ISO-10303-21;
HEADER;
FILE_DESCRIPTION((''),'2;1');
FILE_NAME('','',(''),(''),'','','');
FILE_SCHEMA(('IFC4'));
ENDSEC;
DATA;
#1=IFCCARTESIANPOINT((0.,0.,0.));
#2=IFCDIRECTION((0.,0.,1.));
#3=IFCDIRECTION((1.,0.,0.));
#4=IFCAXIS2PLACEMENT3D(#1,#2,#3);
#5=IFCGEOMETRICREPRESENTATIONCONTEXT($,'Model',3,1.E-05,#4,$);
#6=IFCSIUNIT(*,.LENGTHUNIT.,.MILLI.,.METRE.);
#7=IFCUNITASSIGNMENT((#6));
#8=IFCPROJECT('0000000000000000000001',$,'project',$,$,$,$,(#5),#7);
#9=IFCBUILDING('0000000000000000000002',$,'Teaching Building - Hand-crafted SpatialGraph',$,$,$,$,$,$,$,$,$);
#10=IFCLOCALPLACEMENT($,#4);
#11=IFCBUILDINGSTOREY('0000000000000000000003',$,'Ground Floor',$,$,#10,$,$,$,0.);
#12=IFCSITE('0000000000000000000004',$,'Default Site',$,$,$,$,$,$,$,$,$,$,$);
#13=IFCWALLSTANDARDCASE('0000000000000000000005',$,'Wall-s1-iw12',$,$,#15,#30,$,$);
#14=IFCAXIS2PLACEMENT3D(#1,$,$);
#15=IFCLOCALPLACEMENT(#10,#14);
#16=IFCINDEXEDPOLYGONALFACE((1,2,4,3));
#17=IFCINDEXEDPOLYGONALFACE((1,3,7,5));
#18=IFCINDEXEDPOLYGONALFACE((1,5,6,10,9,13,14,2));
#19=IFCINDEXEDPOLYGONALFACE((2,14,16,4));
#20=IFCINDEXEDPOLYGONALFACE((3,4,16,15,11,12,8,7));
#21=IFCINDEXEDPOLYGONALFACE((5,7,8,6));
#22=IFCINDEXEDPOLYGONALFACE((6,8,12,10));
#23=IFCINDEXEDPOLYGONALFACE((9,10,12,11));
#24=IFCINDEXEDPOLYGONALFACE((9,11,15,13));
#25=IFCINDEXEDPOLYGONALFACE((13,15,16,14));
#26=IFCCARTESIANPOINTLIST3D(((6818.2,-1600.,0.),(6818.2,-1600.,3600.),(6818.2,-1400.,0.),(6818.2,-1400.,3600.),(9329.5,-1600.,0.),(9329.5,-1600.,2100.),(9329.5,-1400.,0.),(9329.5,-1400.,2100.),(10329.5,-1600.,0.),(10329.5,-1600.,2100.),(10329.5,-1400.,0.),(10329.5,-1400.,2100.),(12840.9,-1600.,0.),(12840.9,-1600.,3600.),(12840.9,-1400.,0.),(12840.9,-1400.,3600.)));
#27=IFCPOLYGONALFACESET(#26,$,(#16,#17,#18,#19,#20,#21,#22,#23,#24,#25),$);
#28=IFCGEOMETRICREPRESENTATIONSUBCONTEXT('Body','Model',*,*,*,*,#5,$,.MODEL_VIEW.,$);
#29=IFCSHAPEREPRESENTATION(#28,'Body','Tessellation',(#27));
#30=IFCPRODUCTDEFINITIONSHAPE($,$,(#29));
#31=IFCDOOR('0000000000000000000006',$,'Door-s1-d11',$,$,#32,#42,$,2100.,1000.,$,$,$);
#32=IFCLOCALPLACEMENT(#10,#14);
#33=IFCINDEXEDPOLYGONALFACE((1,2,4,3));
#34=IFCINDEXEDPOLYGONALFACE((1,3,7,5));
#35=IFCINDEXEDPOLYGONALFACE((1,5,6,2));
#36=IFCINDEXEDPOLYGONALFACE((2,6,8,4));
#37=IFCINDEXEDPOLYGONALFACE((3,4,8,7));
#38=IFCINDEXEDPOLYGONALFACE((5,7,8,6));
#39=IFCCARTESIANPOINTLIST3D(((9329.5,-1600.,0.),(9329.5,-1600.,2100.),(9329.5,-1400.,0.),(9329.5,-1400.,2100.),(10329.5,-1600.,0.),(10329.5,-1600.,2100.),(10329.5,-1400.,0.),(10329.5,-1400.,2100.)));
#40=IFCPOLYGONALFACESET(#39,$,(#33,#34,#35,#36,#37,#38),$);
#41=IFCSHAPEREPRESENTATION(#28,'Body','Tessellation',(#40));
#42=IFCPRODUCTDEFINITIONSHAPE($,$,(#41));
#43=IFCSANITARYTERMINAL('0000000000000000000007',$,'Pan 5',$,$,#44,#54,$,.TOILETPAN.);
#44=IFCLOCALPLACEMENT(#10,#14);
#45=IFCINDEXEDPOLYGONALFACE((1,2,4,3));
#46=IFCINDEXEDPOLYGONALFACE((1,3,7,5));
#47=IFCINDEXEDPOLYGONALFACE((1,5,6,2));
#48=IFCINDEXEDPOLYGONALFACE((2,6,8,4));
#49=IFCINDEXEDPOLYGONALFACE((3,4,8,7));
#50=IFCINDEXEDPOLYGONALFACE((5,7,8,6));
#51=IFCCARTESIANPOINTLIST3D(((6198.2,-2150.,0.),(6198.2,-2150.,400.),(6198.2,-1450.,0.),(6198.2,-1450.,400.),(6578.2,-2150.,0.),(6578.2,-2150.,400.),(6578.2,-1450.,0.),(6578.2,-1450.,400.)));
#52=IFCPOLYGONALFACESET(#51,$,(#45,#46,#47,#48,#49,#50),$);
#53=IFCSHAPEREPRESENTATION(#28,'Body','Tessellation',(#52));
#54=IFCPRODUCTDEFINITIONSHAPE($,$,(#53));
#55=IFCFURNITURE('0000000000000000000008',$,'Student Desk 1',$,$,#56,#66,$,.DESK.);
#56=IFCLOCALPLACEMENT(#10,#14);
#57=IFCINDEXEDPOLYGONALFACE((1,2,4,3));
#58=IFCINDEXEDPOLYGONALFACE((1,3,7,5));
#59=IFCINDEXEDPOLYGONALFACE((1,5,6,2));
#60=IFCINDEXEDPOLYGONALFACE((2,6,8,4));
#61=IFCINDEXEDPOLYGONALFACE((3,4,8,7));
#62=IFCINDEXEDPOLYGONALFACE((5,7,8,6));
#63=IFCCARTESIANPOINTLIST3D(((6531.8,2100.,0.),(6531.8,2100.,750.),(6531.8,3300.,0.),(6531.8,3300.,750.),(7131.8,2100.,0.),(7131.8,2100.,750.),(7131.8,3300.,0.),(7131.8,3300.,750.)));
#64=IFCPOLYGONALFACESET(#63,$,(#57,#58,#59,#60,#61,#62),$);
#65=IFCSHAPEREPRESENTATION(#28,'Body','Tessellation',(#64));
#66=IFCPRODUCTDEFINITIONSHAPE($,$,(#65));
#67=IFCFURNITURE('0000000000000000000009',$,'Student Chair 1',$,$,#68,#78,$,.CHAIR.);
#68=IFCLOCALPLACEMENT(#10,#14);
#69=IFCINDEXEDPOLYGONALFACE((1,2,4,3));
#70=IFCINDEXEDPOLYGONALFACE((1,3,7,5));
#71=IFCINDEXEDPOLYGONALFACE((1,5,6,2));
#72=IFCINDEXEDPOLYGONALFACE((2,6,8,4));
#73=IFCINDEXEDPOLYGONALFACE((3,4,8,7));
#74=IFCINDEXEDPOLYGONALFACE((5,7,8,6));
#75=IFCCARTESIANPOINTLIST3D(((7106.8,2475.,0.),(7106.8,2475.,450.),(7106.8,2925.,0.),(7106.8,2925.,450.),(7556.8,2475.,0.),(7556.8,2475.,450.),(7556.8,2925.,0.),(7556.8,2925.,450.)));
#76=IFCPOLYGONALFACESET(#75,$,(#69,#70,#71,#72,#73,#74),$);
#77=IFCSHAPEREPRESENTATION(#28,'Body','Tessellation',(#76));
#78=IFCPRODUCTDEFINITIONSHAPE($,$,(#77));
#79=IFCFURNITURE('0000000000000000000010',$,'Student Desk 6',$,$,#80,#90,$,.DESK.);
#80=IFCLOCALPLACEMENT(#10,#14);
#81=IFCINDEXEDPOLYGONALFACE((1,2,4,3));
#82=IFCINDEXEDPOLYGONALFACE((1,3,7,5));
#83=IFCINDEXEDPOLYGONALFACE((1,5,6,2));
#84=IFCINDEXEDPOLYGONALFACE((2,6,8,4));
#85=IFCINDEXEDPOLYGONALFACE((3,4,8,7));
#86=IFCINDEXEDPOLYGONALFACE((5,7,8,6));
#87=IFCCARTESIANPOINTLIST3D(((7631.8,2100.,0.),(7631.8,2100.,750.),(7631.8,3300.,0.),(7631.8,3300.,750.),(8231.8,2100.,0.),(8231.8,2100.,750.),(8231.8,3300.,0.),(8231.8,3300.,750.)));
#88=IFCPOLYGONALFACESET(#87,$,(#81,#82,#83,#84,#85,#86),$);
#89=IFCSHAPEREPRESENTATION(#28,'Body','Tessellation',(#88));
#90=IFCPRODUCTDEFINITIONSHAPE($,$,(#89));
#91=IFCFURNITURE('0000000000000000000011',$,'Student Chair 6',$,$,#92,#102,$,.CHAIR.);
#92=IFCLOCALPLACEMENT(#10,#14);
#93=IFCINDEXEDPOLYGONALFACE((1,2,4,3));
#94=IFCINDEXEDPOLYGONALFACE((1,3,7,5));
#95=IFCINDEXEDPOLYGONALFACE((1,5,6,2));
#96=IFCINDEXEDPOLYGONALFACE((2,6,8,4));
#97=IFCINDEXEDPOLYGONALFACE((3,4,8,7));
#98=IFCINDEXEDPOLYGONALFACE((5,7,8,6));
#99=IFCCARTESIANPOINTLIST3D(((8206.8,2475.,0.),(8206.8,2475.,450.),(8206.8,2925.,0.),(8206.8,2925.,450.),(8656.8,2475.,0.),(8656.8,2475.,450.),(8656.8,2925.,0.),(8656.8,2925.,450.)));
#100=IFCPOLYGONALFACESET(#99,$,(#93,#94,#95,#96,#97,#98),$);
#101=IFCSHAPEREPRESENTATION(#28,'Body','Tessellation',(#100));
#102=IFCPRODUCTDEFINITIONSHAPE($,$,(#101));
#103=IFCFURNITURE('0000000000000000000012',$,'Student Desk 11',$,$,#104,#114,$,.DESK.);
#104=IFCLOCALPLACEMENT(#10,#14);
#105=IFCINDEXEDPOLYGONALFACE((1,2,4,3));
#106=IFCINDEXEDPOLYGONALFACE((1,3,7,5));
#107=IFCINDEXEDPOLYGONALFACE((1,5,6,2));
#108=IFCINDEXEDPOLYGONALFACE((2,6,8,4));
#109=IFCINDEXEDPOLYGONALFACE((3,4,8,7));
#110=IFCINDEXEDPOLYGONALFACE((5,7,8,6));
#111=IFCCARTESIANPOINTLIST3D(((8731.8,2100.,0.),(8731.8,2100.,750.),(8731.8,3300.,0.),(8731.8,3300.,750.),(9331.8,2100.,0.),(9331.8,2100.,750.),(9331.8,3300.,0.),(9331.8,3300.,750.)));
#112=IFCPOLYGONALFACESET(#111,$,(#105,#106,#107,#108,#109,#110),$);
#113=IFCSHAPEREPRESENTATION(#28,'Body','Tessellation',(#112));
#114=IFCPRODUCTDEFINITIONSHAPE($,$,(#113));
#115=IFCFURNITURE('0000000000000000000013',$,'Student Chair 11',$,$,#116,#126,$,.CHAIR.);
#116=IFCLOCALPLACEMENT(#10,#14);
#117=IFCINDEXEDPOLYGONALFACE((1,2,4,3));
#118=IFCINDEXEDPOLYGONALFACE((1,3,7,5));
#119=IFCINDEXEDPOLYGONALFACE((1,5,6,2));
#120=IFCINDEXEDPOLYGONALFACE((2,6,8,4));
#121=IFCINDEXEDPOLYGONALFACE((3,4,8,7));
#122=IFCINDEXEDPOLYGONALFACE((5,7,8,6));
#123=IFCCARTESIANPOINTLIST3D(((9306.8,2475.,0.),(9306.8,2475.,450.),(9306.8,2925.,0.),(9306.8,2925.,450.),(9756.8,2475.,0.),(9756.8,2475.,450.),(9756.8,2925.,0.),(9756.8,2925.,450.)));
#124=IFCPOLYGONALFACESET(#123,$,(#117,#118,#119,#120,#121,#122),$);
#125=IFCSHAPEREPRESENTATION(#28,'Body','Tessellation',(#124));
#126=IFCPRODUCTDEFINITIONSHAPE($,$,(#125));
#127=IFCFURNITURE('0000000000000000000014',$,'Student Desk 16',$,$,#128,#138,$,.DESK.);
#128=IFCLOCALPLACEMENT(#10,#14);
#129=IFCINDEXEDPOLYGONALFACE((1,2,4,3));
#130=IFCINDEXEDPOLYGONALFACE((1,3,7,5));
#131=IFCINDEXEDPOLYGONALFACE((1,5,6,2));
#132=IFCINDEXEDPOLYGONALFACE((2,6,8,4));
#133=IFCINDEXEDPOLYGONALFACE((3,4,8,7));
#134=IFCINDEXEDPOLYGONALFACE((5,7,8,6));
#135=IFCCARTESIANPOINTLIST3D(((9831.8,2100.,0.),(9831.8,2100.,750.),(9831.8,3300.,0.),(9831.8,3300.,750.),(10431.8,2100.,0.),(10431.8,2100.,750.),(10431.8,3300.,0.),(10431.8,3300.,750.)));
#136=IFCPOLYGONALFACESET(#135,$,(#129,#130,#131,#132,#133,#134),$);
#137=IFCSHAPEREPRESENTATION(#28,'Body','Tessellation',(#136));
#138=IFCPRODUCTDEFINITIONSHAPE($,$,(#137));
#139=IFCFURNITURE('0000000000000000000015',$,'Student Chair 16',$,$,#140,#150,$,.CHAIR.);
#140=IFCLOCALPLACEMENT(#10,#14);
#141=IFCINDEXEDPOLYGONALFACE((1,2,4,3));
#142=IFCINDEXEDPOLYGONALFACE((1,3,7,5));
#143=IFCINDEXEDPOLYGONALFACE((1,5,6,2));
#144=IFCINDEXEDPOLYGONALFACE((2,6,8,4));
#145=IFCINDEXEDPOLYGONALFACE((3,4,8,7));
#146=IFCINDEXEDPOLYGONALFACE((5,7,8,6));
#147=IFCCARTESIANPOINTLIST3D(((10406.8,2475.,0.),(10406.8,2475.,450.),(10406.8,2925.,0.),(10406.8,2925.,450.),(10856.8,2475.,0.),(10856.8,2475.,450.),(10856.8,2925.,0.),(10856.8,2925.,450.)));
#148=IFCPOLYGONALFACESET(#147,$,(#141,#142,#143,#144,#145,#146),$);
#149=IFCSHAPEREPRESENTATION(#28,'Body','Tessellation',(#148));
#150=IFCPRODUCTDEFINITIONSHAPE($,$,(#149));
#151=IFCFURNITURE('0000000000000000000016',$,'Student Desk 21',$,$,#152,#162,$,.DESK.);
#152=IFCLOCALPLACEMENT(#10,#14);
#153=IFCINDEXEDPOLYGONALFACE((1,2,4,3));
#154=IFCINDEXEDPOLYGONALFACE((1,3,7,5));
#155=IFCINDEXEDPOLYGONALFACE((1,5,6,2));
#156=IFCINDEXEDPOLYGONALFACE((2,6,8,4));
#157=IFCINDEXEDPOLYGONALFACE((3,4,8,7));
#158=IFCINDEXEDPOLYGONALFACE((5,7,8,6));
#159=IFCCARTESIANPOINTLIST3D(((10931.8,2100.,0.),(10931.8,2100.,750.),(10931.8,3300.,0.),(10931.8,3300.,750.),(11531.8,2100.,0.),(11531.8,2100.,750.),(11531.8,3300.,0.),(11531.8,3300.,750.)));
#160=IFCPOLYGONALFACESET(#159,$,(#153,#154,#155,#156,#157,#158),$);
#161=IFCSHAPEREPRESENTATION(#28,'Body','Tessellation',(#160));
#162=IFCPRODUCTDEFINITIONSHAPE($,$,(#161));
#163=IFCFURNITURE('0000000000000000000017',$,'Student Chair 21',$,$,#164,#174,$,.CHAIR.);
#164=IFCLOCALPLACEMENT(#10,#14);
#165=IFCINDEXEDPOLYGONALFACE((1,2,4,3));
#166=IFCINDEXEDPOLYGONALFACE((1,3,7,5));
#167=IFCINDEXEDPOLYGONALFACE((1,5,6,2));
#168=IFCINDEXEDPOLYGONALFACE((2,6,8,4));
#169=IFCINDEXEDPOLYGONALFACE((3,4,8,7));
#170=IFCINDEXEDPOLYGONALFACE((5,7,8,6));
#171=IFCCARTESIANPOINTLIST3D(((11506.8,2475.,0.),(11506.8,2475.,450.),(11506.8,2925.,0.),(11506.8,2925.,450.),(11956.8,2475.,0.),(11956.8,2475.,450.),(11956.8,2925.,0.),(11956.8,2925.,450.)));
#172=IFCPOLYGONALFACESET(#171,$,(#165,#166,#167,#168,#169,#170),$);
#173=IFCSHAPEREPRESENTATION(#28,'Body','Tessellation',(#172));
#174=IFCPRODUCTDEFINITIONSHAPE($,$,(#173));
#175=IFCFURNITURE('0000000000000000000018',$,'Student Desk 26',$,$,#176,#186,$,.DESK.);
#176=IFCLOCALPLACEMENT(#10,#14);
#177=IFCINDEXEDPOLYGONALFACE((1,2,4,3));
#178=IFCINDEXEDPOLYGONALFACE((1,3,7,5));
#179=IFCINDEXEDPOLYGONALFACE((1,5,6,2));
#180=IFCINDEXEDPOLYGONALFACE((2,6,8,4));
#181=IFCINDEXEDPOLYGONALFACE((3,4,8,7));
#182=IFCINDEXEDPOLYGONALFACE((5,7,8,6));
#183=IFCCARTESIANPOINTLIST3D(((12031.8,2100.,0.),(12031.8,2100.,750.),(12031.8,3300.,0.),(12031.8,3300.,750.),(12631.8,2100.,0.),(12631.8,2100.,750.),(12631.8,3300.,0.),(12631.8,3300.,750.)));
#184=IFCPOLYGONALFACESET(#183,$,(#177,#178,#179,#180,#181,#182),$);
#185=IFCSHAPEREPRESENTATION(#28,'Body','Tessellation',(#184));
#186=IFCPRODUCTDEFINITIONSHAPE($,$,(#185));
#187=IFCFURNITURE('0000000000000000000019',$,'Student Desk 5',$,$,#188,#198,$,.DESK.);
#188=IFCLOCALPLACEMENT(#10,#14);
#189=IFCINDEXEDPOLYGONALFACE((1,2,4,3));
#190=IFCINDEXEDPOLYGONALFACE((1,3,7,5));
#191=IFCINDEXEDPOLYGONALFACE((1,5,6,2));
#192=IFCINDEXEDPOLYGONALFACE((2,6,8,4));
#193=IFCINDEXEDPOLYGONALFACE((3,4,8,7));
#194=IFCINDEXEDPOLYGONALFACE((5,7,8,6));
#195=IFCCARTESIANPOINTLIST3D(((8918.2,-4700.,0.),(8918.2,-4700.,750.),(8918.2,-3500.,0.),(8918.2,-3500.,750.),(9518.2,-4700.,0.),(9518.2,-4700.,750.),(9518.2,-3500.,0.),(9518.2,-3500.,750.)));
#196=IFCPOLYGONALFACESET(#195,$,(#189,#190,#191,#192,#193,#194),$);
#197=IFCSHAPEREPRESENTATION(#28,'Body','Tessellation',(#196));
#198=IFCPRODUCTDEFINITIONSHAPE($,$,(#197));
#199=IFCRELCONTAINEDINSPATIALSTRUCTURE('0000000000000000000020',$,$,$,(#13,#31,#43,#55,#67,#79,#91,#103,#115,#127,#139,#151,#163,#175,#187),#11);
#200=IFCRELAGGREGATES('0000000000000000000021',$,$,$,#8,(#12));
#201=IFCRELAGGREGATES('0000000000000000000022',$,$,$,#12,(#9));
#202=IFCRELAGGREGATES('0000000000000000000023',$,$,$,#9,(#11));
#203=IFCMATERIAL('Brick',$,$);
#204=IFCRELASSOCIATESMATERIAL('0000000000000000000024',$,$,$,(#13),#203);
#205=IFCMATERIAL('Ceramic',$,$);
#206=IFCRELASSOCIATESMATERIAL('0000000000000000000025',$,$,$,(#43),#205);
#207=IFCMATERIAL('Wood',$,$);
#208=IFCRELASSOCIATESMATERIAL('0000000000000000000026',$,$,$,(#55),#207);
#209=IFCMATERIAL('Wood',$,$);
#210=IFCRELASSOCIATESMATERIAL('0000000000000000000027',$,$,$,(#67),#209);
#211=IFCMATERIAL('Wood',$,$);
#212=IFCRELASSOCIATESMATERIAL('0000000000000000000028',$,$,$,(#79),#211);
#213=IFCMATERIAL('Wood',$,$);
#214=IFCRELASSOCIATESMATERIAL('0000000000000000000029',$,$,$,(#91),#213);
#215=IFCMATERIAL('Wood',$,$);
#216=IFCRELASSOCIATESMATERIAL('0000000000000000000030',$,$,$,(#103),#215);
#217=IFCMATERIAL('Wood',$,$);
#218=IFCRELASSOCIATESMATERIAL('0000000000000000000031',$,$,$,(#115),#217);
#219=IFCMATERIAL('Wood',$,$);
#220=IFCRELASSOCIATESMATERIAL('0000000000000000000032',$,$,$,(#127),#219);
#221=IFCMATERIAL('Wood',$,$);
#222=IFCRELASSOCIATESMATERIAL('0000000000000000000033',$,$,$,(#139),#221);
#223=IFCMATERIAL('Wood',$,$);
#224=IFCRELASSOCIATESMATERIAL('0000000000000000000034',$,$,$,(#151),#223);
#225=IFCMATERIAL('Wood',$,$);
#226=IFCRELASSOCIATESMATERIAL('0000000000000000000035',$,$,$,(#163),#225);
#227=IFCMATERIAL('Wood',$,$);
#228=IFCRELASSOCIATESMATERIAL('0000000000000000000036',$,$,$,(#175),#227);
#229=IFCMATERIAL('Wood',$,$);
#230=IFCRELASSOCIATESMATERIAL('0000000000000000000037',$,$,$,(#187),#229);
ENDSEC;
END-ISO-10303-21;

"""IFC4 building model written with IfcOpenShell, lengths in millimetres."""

from ifc_helpers import new_model, si_unit, frame, frame_2d, origin_with_axes, origin_2d, place, context, subcontext, project, spatial, rectangle, extrude, material, element, fill, save


model = new_model("IFC4")

# Units and contexts
model_context = context("Model", 3, precision=1e-05, world=origin_with_axes())
body_context = subcontext(model_context, "Body", "Model", "MODEL_VIEW")
ifc_project = project(units=[si_unit("LENGTHUNIT", "METRE", prefix="MILLI")], contexts=[model_context])

# Site, building, storey
site = spatial("IfcSite", under=ifc_project, Name="Default Site")
building = spatial("IfcBuilding", under=site, Name="Teaching Building - Hand-crafted SpatialGraph")
storey_placement = place(None, origin_with_axes())
storey = spatial("IfcBuildingStorey", under=building, at=storey_placement, Name="Ground Floor", Elevation=0.0)

# Wall, opening, door
ifc_material_1 = material(Name="Brick")
wall_placement = place(storey_placement, frame((6818.2, -1500.0, 0.0), z_axis=(0.0, 0.0, 1.0), x_axis=(1.0, 0.0, 0.0)))
wall = element("IfcWallStandardCase", 1, at=wall_placement, inside=storey, material=ifc_material_1, Name="Wall-s1-iw12", context=body_context, shape_type="SweptSolid", body=[
    extrude(rectangle(XDim=6022.7, YDim=200.0, at=frame_2d((3011.4, 0.0))), origin_with_axes(), (0.0, 0.0, 1.0), 3600.0),
])
opening_placement = place(wall_placement, frame((2511.4, 0.0, 0.0), z_axis=(0.0, 0.0, 1.0), x_axis=(1.0, 0.0, 0.0)))
opening = element("IfcOpeningElement", 2, at=opening_placement, cuts=wall, context=body_context, shape_type="SweptSolid", body=[
    extrude(rectangle(XDim=1000.0, YDim=400.0, at=frame_2d((500.0, 0.0))), origin_with_axes(), (0.0, 0.0, 1.0), 2100.0),
])
door_placement = place(storey_placement, frame((9329.5, -1500.0, 0.0), z_axis=(0.0, 0.0, 1.0), x_axis=(1.0, 0.0, 0.0)))
door = element("IfcDoor", 3, at=door_placement, inside=storey, Name="Door-s1-d11", OverallHeight=2100.0, OverallWidth=1000.0, context=body_context, shape_type="SweptSolid", body=[
    extrude(rectangle(XDim=1000.0, YDim=200.0, at=frame_2d((500.0, 0.0))), origin_with_axes(), (0.0, 0.0, 1.0), 2100.0),
])
fill(opening, door)

# Sanitary terminal
ifc_material_2 = material(Name="Ceramic")
sanitary_terminal_placement = place(storey_placement, frame((6388.2, -1800.0, 0.0), z_axis=(0.0, 0.0, 1.0), x_axis=(0.0, 1.0, 0.0)))
element("IfcSanitaryTerminal", 4, at=sanitary_terminal_placement, inside=storey, material=ifc_material_2, Name="Pan 5", PredefinedType="TOILETPAN", context=body_context, shape_type="SweptSolid", body=[
    extrude(rectangle(XDim=700.0, YDim=380.0, at=origin_2d()), origin_with_axes(), (0.0, 0.0, 1.0), 400.0),
])

# Furniture
ifc_material_3 = material(Name="Wood")
furniture_1_placement = place(storey_placement, frame((6831.8, 2700.0, 0.0), z_axis=(0.0, 0.0, 1.0), x_axis=(0.0, 1.0, 0.0)))
element("IfcFurniture", 5, at=furniture_1_placement, inside=storey, material=ifc_material_3, Name="Student Desk 1", PredefinedType="DESK", context=body_context, shape_type="SweptSolid", body=[
    extrude(rectangle(XDim=1200.0, YDim=600.0, at=origin_2d()), origin_with_axes(), (0.0, 0.0, 1.0), 750.0),
])
ifc_material_4 = material(Name="Wood")
furniture_2_placement = place(storey_placement, frame((7331.8, 2700.0, 0.0), z_axis=(0.0, 0.0, 1.0), x_axis=(1.0, 0.0, 0.0)))
element("IfcFurniture", 6, at=furniture_2_placement, inside=storey, material=ifc_material_4, Name="Student Chair 1", PredefinedType="CHAIR", context=body_context, shape_type="SweptSolid", body=[
    extrude(rectangle(XDim=450.0, YDim=450.0, at=origin_2d()), origin_with_axes(), (0.0, 0.0, 1.0), 450.0),
])
ifc_material_5 = material(Name="Wood")
furniture_3_placement = place(storey_placement, frame((7931.8, 2700.0, 0.0), z_axis=(0.0, 0.0, 1.0), x_axis=(0.0, 1.0, 0.0)))
element("IfcFurniture", 7, at=furniture_3_placement, inside=storey, material=ifc_material_5, Name="Student Desk 6", PredefinedType="DESK", context=body_context, shape_type="SweptSolid", body=[
    extrude(rectangle(XDim=1200.0, YDim=600.0, at=origin_2d()), origin_with_axes(), (0.0, 0.0, 1.0), 750.0),
])
ifc_material_6 = material(Name="Wood")
furniture_4_placement = place(storey_placement, frame((8431.8, 2700.0, 0.0), z_axis=(0.0, 0.0, 1.0), x_axis=(1.0, 0.0, 0.0)))
element("IfcFurniture", 8, at=furniture_4_placement, inside=storey, material=ifc_material_6, Name="Student Chair 6", PredefinedType="CHAIR", context=body_context, shape_type="SweptSolid", body=[
    extrude(rectangle(XDim=450.0, YDim=450.0, at=origin_2d()), origin_with_axes(), (0.0, 0.0, 1.0), 450.0),
])
ifc_material_7 = material(Name="Wood")
furniture_5_placement = place(storey_placement, frame((9031.8, 2700.0, 0.0), z_axis=(0.0, 0.0, 1.0), x_axis=(0.0, 1.0, 0.0)))
element("IfcFurniture", 9, at=furniture_5_placement, inside=storey, material=ifc_material_7, Name="Student Desk 11", PredefinedType="DESK", context=body_context, shape_type="SweptSolid", body=[
    extrude(rectangle(XDim=1200.0, YDim=600.0, at=origin_2d()), origin_with_axes(), (0.0, 0.0, 1.0), 750.0),
])
ifc_material_8 = material(Name="Wood")
furniture_6_placement = place(storey_placement, frame((9531.8, 2700.0, 0.0), z_axis=(0.0, 0.0, 1.0), x_axis=(1.0, 0.0, 0.0)))
element("IfcFurniture", 10, at=furniture_6_placement, inside=storey, material=ifc_material_8, Name="Student Chair 11", PredefinedType="CHAIR", context=body_context, shape_type="SweptSolid", body=[
    extrude(rectangle(XDim=450.0, YDim=450.0, at=origin_2d()), origin_with_axes(), (0.0, 0.0, 1.0), 450.0),
])
ifc_material_9 = material(Name="Wood")
furniture_7_placement = place(storey_placement, frame((10131.8, 2700.0, 0.0), z_axis=(0.0, 0.0, 1.0), x_axis=(0.0, 1.0, 0.0)))
element("IfcFurniture", 11, at=furniture_7_placement, inside=storey, material=ifc_material_9, Name="Student Desk 16", PredefinedType="DESK", context=body_context, shape_type="SweptSolid", body=[
    extrude(rectangle(XDim=1200.0, YDim=600.0, at=origin_2d()), origin_with_axes(), (0.0, 0.0, 1.0), 750.0),
])
ifc_material_10 = material(Name="Wood")
furniture_8_placement = place(storey_placement, frame((10631.8, 2700.0, 0.0), z_axis=(0.0, 0.0, 1.0), x_axis=(1.0, 0.0, 0.0)))
element("IfcFurniture", 12, at=furniture_8_placement, inside=storey, material=ifc_material_10, Name="Student Chair 16", PredefinedType="CHAIR", context=body_context, shape_type="SweptSolid", body=[
    extrude(rectangle(XDim=450.0, YDim=450.0, at=origin_2d()), origin_with_axes(), (0.0, 0.0, 1.0), 450.0),
])
ifc_material_11 = material(Name="Wood")
furniture_9_placement = place(storey_placement, frame((11231.8, 2700.0, 0.0), z_axis=(0.0, 0.0, 1.0), x_axis=(0.0, 1.0, 0.0)))
element("IfcFurniture", 13, at=furniture_9_placement, inside=storey, material=ifc_material_11, Name="Student Desk 21", PredefinedType="DESK", context=body_context, shape_type="SweptSolid", body=[
    extrude(rectangle(XDim=1200.0, YDim=600.0, at=origin_2d()), origin_with_axes(), (0.0, 0.0, 1.0), 750.0),
])
ifc_material_12 = material(Name="Wood")
furniture_10_placement = place(storey_placement, frame((11731.8, 2700.0, 0.0), z_axis=(0.0, 0.0, 1.0), x_axis=(1.0, 0.0, 0.0)))
element("IfcFurniture", 14, at=furniture_10_placement, inside=storey, material=ifc_material_12, Name="Student Chair 21", PredefinedType="CHAIR", context=body_context, shape_type="SweptSolid", body=[
    extrude(rectangle(XDim=450.0, YDim=450.0, at=origin_2d()), origin_with_axes(), (0.0, 0.0, 1.0), 450.0),
])
ifc_material_13 = material(Name="Wood")
furniture_11_placement = place(storey_placement, frame((12331.8, 2700.0, 0.0), z_axis=(0.0, 0.0, 1.0), x_axis=(0.0, 1.0, 0.0)))
element("IfcFurniture", 15, at=furniture_11_placement, inside=storey, material=ifc_material_13, Name="Student Desk 26", PredefinedType="DESK", context=body_context, shape_type="SweptSolid", body=[
    extrude(rectangle(XDim=1200.0, YDim=600.0, at=origin_2d()), origin_with_axes(), (0.0, 0.0, 1.0), 750.0),
])
ifc_material_14 = material(Name="Wood")
furniture_12_placement = place(storey_placement, frame((9218.2, -4100.0, 0.0), z_axis=(0.0, 0.0, 1.0), x_axis=(0.0, 1.0, 0.0)))
element("IfcFurniture", 16, at=furniture_12_placement, inside=storey, material=ifc_material_14, Name="Student Desk 5", PredefinedType="DESK", context=body_context, shape_type="SweptSolid", body=[
    extrude(rectangle(XDim=1200.0, YDim=600.0, at=origin_2d()), origin_with_axes(), (0.0, 0.0, 1.0), 750.0),
])

save(model, "model.ifc")
